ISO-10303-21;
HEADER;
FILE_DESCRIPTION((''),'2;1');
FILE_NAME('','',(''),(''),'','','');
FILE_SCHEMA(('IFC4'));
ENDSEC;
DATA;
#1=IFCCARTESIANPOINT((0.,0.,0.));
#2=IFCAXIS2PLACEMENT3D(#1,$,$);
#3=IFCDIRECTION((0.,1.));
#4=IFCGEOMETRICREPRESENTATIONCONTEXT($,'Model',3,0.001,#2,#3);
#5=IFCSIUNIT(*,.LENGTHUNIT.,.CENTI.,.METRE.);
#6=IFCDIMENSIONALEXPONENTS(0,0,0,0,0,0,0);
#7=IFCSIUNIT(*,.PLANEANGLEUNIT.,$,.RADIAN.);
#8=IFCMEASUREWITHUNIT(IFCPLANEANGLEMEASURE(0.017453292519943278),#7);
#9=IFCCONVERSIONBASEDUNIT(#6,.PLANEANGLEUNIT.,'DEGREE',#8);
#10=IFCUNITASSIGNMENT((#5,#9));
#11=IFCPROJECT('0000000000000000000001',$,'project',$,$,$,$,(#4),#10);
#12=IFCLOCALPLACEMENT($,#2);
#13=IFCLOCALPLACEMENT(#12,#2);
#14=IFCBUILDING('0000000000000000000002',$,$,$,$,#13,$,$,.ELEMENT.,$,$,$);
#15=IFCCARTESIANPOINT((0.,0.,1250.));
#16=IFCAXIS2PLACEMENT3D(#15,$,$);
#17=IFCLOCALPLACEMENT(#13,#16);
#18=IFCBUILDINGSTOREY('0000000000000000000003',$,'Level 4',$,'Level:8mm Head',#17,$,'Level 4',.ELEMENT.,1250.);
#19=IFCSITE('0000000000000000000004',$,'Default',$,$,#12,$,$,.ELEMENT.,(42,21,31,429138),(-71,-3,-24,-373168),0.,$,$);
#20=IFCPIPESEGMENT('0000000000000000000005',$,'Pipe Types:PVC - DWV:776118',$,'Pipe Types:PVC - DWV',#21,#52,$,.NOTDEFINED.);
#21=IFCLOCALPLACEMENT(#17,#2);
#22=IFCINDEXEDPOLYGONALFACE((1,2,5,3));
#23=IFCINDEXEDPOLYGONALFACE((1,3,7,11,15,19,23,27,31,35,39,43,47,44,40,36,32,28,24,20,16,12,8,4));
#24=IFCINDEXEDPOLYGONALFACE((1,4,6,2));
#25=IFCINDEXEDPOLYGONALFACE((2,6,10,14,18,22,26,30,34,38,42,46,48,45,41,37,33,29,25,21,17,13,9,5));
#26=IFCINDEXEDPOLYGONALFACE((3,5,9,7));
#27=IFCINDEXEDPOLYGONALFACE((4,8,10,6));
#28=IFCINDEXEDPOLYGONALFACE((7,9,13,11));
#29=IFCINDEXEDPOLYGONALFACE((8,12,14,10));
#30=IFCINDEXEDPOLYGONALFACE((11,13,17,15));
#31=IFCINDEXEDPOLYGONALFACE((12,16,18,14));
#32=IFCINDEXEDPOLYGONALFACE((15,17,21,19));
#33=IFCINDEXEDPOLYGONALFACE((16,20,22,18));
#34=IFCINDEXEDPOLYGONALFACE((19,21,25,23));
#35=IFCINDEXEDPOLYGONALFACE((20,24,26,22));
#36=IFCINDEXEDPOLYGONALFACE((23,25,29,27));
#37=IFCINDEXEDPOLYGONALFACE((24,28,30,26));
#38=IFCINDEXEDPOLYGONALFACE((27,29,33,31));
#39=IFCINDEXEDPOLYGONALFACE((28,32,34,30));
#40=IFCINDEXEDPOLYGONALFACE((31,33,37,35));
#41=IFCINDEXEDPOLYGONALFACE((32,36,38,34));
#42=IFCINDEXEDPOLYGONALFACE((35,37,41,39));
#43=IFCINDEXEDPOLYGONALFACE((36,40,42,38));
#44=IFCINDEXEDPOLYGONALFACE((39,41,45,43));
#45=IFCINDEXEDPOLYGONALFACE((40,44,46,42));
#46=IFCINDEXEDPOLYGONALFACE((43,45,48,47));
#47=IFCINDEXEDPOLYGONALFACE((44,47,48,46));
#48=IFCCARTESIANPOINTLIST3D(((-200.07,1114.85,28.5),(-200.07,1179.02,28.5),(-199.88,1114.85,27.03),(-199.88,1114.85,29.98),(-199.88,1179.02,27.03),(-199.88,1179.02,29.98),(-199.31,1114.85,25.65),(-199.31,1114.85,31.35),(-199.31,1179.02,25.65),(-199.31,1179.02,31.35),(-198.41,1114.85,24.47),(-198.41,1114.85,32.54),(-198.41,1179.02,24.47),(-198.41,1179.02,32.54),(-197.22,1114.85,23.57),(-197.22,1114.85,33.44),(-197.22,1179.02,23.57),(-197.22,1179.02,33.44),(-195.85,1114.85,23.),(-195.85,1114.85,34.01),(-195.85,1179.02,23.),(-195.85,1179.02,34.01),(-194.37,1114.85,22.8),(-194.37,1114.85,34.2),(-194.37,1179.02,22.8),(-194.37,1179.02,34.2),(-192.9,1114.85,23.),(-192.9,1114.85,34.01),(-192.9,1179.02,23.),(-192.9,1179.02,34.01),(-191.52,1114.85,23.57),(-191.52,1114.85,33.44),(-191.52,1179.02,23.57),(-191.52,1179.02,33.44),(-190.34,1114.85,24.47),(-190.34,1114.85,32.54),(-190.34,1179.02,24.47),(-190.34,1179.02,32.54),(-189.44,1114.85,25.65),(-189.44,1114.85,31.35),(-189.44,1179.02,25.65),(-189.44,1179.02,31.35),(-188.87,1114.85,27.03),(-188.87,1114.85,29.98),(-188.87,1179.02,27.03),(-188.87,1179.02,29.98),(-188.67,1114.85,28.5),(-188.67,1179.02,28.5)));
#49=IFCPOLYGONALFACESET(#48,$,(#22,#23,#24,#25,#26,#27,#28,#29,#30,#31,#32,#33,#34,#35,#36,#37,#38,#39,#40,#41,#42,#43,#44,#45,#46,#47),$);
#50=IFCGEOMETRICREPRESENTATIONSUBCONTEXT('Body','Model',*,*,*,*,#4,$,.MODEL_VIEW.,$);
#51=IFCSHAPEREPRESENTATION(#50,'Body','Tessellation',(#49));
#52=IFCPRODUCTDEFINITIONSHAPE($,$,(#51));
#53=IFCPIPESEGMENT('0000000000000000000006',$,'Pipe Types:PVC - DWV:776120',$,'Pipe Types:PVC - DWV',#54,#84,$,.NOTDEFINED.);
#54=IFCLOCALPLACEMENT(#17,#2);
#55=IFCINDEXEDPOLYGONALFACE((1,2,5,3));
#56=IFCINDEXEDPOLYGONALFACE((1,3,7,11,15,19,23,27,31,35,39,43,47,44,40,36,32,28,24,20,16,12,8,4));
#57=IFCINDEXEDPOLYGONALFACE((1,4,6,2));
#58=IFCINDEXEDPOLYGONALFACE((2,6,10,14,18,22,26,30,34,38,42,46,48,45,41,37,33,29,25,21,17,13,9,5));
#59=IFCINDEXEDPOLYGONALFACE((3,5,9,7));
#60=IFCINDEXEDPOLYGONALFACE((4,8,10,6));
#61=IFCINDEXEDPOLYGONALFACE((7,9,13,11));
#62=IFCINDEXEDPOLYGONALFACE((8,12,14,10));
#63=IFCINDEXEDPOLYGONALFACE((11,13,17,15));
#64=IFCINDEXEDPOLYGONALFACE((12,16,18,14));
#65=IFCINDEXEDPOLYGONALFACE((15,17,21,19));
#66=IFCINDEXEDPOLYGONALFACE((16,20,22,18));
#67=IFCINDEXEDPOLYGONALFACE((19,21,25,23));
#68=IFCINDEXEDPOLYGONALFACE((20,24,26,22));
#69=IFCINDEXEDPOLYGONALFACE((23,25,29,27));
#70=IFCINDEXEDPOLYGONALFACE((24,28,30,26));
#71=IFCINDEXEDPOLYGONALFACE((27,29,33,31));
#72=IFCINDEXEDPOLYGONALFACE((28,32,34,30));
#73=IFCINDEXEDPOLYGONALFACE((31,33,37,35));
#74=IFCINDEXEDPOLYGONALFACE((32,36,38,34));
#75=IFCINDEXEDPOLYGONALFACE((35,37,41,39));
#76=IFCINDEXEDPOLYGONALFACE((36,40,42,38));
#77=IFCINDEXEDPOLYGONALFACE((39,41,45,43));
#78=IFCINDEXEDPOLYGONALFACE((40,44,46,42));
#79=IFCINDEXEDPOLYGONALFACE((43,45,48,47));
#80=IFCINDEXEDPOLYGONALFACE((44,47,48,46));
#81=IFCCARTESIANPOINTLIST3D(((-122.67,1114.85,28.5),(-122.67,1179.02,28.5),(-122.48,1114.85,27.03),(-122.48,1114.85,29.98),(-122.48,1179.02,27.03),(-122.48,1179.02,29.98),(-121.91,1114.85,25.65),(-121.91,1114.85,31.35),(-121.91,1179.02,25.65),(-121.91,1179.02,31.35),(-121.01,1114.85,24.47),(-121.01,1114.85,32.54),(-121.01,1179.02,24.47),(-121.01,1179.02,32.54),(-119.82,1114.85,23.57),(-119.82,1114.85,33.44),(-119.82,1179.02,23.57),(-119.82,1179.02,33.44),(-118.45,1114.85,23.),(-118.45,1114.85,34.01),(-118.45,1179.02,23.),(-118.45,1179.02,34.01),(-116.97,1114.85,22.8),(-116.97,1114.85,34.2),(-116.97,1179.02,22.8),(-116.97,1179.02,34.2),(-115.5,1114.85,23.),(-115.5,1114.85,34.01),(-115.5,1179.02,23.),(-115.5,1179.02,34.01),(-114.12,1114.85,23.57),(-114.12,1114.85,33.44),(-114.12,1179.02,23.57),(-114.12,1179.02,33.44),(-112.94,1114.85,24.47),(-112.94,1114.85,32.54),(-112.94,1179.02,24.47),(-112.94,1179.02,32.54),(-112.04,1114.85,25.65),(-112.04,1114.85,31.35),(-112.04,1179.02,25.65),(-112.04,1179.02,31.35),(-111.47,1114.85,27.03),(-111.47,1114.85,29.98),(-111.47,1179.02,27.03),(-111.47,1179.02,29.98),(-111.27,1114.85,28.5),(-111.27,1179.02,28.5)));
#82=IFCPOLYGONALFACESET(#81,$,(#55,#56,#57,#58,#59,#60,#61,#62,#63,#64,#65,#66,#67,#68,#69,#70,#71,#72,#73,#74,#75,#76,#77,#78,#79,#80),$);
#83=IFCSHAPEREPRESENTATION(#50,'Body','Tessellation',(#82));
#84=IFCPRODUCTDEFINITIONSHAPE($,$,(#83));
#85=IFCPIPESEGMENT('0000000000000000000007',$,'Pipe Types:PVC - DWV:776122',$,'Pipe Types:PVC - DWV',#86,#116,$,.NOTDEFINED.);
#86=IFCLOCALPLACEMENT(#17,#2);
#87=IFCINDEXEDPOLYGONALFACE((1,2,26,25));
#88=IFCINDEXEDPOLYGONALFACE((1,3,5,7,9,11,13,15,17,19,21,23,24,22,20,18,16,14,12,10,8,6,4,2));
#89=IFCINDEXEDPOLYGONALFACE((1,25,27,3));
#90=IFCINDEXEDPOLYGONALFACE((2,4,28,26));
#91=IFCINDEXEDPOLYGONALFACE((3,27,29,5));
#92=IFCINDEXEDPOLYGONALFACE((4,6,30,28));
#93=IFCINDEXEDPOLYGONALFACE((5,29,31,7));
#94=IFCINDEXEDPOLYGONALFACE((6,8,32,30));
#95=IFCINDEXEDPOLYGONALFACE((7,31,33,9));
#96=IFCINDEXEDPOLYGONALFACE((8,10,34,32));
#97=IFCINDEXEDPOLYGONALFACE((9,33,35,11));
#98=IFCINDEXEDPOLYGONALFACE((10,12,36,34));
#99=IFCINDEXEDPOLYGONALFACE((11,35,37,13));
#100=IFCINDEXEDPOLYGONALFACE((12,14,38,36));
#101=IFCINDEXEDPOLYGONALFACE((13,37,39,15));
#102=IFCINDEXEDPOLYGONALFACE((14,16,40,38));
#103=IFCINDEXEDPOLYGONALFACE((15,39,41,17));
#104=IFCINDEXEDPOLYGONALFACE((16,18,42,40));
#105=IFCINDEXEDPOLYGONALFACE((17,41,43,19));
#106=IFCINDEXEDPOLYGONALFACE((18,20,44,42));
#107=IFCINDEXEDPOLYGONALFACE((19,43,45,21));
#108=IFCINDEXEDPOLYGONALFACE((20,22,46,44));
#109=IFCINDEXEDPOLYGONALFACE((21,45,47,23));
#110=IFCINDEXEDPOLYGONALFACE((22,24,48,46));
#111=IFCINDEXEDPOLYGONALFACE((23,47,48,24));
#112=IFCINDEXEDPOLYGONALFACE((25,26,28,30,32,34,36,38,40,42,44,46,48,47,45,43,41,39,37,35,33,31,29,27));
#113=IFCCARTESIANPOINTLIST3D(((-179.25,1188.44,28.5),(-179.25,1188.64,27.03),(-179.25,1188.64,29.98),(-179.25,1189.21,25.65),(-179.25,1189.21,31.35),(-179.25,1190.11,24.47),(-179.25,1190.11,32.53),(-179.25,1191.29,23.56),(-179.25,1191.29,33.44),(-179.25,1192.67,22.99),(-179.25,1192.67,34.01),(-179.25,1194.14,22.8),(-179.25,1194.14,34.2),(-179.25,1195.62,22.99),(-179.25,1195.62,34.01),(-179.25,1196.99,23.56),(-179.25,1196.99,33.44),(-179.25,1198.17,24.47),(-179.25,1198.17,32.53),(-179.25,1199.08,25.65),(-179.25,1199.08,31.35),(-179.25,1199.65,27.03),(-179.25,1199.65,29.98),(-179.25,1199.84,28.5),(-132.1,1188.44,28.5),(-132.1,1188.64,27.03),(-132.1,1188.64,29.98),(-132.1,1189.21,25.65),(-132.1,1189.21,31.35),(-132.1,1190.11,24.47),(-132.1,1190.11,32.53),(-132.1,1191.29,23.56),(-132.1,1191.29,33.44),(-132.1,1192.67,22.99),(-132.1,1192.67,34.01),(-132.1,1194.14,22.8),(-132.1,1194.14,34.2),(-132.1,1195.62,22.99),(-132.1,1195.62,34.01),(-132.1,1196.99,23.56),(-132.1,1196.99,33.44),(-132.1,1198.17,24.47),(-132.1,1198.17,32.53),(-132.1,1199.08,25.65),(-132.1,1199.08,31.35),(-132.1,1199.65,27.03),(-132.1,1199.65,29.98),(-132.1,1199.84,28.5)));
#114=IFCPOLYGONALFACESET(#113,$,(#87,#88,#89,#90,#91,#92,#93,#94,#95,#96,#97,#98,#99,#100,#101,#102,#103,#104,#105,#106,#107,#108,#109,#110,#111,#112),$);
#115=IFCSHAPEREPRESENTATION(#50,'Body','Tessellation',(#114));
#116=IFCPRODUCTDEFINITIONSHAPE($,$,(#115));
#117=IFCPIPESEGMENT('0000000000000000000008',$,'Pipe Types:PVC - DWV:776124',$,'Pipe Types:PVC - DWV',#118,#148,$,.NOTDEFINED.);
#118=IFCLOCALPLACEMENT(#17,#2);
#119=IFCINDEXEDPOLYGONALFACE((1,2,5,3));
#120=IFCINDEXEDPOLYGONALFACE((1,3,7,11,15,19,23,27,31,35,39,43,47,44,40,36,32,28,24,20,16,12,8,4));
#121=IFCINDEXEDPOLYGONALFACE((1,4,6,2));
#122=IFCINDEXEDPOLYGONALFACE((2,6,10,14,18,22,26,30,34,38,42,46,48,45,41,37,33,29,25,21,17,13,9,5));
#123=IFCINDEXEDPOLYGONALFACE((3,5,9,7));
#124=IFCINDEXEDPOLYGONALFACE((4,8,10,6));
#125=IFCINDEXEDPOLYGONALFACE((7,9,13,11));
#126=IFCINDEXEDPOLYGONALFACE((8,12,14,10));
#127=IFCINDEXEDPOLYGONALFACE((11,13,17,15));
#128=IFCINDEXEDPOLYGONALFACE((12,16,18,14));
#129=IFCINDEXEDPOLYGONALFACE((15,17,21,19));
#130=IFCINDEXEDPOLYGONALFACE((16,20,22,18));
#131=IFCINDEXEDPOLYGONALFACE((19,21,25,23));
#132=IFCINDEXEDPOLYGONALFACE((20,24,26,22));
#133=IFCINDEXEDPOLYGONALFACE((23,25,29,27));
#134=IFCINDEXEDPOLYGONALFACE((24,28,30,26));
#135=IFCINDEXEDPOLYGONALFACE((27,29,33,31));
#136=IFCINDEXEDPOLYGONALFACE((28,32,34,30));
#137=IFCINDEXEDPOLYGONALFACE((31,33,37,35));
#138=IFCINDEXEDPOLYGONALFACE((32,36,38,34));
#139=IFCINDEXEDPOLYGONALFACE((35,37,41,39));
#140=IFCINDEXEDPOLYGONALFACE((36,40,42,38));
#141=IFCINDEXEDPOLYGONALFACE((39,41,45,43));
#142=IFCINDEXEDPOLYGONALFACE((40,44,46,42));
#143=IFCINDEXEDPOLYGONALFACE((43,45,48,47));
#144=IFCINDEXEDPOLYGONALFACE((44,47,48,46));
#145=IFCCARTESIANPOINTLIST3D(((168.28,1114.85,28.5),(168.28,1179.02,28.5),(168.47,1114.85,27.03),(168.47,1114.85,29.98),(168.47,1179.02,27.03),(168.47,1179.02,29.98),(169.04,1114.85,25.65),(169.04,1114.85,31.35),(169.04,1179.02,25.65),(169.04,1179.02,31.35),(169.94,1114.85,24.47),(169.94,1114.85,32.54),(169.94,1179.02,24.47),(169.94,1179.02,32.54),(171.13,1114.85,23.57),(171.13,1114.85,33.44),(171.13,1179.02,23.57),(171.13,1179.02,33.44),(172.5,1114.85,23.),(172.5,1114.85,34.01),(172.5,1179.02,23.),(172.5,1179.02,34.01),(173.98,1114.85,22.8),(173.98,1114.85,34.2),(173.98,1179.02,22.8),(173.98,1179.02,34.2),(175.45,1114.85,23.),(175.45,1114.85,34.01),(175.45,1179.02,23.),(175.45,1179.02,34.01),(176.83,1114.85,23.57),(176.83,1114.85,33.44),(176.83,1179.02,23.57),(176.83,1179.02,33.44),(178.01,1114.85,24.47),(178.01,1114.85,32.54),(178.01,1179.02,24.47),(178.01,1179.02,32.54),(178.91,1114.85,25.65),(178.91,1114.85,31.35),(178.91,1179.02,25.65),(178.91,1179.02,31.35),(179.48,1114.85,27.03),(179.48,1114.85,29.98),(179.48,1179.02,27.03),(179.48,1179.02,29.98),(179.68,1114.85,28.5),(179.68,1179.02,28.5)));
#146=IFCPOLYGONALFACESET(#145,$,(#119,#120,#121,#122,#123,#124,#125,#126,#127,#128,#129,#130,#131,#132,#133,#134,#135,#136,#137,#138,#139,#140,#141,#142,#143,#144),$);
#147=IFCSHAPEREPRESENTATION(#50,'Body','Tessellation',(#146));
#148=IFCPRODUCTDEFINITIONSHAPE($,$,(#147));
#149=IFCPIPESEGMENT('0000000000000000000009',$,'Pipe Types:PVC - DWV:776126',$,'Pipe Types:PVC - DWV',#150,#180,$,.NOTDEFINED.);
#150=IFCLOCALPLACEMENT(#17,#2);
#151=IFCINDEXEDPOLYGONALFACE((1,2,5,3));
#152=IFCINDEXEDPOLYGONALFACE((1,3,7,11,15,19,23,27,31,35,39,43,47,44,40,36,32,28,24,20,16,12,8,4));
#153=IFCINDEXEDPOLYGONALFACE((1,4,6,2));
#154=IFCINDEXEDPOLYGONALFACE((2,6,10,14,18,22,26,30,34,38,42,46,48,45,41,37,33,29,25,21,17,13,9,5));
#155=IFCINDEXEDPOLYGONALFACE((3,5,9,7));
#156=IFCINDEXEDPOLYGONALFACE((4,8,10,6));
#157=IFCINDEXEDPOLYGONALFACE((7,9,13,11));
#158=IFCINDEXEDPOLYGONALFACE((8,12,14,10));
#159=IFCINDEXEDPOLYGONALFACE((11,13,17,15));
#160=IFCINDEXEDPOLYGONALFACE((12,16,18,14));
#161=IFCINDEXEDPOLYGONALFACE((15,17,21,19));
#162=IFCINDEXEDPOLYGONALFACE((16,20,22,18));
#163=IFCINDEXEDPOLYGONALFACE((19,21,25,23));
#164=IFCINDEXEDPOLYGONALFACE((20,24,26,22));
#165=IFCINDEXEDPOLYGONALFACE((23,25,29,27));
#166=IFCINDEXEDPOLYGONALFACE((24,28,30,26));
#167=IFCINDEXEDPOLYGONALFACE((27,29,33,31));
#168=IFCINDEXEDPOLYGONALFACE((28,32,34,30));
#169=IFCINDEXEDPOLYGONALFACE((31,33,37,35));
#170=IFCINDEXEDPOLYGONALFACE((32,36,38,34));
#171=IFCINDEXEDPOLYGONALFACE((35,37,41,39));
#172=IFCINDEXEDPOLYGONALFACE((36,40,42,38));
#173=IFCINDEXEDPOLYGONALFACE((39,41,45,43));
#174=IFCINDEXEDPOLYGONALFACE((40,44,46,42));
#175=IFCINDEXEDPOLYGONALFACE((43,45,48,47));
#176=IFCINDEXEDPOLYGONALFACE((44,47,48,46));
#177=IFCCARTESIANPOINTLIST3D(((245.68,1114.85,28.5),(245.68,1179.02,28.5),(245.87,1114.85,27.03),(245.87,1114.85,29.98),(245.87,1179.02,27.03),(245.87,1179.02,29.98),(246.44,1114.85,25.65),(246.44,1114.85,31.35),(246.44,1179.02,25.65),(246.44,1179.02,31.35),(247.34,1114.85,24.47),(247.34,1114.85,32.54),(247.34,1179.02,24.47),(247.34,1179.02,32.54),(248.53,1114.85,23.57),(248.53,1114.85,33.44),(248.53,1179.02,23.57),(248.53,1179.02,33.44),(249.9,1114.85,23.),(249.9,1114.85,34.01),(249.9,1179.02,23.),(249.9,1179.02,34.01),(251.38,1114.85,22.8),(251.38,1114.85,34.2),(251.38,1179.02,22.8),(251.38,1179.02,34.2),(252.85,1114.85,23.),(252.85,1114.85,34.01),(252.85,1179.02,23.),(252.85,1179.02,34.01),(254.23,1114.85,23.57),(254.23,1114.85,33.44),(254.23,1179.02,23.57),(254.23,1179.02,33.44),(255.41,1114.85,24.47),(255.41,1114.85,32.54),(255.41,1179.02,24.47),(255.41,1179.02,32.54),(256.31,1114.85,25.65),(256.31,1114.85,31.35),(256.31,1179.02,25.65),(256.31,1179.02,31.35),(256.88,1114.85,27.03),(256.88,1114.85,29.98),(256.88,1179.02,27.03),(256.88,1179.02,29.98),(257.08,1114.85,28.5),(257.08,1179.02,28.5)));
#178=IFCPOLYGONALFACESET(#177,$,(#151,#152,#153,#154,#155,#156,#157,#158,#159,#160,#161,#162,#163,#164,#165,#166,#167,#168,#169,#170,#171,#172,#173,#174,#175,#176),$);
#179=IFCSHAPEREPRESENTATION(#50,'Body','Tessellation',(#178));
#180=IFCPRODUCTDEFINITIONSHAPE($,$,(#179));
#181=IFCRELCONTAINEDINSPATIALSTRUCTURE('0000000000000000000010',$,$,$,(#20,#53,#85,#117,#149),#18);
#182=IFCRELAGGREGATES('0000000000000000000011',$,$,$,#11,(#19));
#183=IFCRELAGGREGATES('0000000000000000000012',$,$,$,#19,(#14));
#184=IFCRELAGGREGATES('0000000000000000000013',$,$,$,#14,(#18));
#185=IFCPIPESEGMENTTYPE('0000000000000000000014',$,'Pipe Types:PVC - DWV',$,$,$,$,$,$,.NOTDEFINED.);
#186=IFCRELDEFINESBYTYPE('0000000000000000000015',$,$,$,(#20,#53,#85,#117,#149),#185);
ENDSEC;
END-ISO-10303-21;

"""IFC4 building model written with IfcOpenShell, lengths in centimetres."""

from ifc_helpers import new_model, entity, si_unit, converted_unit, direction, frame, origin, place, context, subcontext, project, spatial, arc, indexed_curve, outline, extrude, type_object, element, save


model = new_model("IFC4")

# Units and contexts
model_context = context("Model", 3, precision=0.001, world=origin(), true_north=direction((0.0, 1.0)))
body_context = subcontext(model_context, "Body", "Model", "MODEL_VIEW")
ifc_project = project(units=[si_unit("LENGTHUNIT", "METRE", prefix="CENTI"), converted_unit("PLANEANGLEUNIT", "DEGREE", entity("IfcPlaneAngleMeasure", 0.017453292519943278), si_unit("PLANEANGLEUNIT", "RADIAN"), dimensions=[0, 0, 0, 0, 0, 0, 0])], contexts=[model_context])

# Site, building, storey
site_placement = place(None, origin())
site = spatial("IfcSite", under=ifc_project, at=site_placement, Name="Default", CompositionType="ELEMENT", RefLatitude=(42, 21, 31, 429138), RefLongitude=(-71, -3, -24, -373168), RefElevation=0.0)
building_placement = place(site_placement, origin())
building = spatial("IfcBuilding", under=site, at=building_placement, CompositionType="ELEMENT")
storey_placement = place(building_placement, frame((0.0, 0.0, 1250.0)))
storey = spatial("IfcBuildingStorey", under=building, at=storey_placement, Name="Level 4", ObjectType="Level:8mm Head", LongName="Level 4", CompositionType="ELEMENT", Elevation=1250.0)

# Pipe segments
pipe_segment_type = type_object("IfcPipeSegmentType", Name="Pipe Types:PVC - DWV", PredefinedType="NOTDEFINED")
pipe_segment_1_placement = place(storey_placement, origin())
element("IfcPipeSegment", 1, at=pipe_segment_1_placement, inside=storey, type_object=pipe_segment_type, Name="Pipe Types:PVC - DWV:776118", ObjectType="Pipe Types:PVC - DWV", PredefinedType="NOTDEFINED", context=body_context, shape_type="SweptSolid", body=[
    extrude(outline(indexed_curve([(5.7, 0.0), (4.03, 4.03), (0.0, 5.7), (-4.03, 4.03), (-5.7, 0.0), (-4.03, -4.03), (0.0, -5.7), (4.03, -4.03)], segments=[arc(1, 2, 3), arc(3, 4, 5), arc(5, 6, 7), arc(7, 8, 1)], self_intersect=False)), frame((-194.37, 1114.85, 28.5), z_axis=(0.0, 1.0, 0.0), x_axis=(-1.0, 0.0, 0.0)), (0.0, 0.0, 1.0), 64.18),
])
pipe_segment_2_placement = place(storey_placement, origin())
element("IfcPipeSegment", 2, at=pipe_segment_2_placement, inside=storey, type_object=pipe_segment_type, Name="Pipe Types:PVC - DWV:776120", ObjectType="Pipe Types:PVC - DWV", PredefinedType="NOTDEFINED", context=body_context, shape_type="SweptSolid", body=[
    extrude(outline(indexed_curve([(5.7, 0.0), (4.03, 4.03), (0.0, 5.7), (-4.03, 4.03), (-5.7, 0.0), (-4.03, -4.03), (0.0, -5.7), (4.03, -4.03)], segments=[arc(1, 2, 3), arc(3, 4, 5), arc(5, 6, 7), arc(7, 8, 1)], self_intersect=False)), frame((-116.97, 1114.85, 28.5), z_axis=(0.0, 1.0, 0.0), x_axis=(-1.0, 0.0, 0.0)), (0.0, 0.0, 1.0), 64.18),
])
pipe_segment_3_placement = place(storey_placement, origin())
element("IfcPipeSegment", 3, at=pipe_segment_3_placement, inside=storey, type_object=pipe_segment_type, Name="Pipe Types:PVC - DWV:776122", ObjectType="Pipe Types:PVC - DWV", PredefinedType="NOTDEFINED", context=body_context, shape_type="SweptSolid", body=[
    extrude(outline(indexed_curve([(5.7, 0.0), (4.03, 4.03), (0.0, 5.7), (-4.03, 4.03), (-5.7, 0.0), (-4.03, -4.03), (0.0, -5.7), (4.03, -4.03)], segments=[arc(1, 2, 3), arc(3, 4, 5), arc(5, 6, 7), arc(7, 8, 1)], self_intersect=False)), frame((-179.25, 1194.14, 28.5), z_axis=(1.0, 0.0, 0.0), x_axis=(0.0, 1.0, 0.0)), (0.0, 0.0, 1.0), 47.16),
])
pipe_segment_4_placement = place(storey_placement, origin())
element("IfcPipeSegment", 4, at=pipe_segment_4_placement, inside=storey, type_object=pipe_segment_type, Name="Pipe Types:PVC - DWV:776124", ObjectType="Pipe Types:PVC - DWV", PredefinedType="NOTDEFINED", context=body_context, shape_type="SweptSolid", body=[
    extrude(outline(indexed_curve([(5.7, 0.0), (4.03, 4.03), (0.0, 5.7), (-4.03, 4.03), (-5.7, 0.0), (-4.03, -4.03), (0.0, -5.7), (4.03, -4.03)], segments=[arc(1, 2, 3), arc(3, 4, 5), arc(5, 6, 7), arc(7, 8, 1)], self_intersect=False)), frame((173.98, 1114.85, 28.5), z_axis=(0.0, 1.0, 0.0), x_axis=(-1.0, 0.0, 0.0)), (0.0, 0.0, 1.0), 64.18),
])
pipe_segment_5_placement = place(storey_placement, origin())
element("IfcPipeSegment", 5, at=pipe_segment_5_placement, inside=storey, type_object=pipe_segment_type, Name="Pipe Types:PVC - DWV:776126", ObjectType="Pipe Types:PVC - DWV", PredefinedType="NOTDEFINED", context=body_context, shape_type="SweptSolid", body=[
    extrude(outline(indexed_curve([(5.7, 0.0), (4.03, 4.03), (0.0, 5.7), (-4.03, 4.03), (-5.7, 0.0), (-4.03, -4.03), (0.0, -5.7), (4.03, -4.03)], segments=[arc(1, 2, 3), arc(3, 4, 5), arc(5, 6, 7), arc(7, 8, 1)], self_intersect=False)), frame((251.38, 1114.85, 28.5), z_axis=(0.0, 1.0, 0.0), x_axis=(-1.0, 0.0, 0.0)), (0.0, 0.0, 1.0), 64.18),
])

save(model, "model.ifc")
